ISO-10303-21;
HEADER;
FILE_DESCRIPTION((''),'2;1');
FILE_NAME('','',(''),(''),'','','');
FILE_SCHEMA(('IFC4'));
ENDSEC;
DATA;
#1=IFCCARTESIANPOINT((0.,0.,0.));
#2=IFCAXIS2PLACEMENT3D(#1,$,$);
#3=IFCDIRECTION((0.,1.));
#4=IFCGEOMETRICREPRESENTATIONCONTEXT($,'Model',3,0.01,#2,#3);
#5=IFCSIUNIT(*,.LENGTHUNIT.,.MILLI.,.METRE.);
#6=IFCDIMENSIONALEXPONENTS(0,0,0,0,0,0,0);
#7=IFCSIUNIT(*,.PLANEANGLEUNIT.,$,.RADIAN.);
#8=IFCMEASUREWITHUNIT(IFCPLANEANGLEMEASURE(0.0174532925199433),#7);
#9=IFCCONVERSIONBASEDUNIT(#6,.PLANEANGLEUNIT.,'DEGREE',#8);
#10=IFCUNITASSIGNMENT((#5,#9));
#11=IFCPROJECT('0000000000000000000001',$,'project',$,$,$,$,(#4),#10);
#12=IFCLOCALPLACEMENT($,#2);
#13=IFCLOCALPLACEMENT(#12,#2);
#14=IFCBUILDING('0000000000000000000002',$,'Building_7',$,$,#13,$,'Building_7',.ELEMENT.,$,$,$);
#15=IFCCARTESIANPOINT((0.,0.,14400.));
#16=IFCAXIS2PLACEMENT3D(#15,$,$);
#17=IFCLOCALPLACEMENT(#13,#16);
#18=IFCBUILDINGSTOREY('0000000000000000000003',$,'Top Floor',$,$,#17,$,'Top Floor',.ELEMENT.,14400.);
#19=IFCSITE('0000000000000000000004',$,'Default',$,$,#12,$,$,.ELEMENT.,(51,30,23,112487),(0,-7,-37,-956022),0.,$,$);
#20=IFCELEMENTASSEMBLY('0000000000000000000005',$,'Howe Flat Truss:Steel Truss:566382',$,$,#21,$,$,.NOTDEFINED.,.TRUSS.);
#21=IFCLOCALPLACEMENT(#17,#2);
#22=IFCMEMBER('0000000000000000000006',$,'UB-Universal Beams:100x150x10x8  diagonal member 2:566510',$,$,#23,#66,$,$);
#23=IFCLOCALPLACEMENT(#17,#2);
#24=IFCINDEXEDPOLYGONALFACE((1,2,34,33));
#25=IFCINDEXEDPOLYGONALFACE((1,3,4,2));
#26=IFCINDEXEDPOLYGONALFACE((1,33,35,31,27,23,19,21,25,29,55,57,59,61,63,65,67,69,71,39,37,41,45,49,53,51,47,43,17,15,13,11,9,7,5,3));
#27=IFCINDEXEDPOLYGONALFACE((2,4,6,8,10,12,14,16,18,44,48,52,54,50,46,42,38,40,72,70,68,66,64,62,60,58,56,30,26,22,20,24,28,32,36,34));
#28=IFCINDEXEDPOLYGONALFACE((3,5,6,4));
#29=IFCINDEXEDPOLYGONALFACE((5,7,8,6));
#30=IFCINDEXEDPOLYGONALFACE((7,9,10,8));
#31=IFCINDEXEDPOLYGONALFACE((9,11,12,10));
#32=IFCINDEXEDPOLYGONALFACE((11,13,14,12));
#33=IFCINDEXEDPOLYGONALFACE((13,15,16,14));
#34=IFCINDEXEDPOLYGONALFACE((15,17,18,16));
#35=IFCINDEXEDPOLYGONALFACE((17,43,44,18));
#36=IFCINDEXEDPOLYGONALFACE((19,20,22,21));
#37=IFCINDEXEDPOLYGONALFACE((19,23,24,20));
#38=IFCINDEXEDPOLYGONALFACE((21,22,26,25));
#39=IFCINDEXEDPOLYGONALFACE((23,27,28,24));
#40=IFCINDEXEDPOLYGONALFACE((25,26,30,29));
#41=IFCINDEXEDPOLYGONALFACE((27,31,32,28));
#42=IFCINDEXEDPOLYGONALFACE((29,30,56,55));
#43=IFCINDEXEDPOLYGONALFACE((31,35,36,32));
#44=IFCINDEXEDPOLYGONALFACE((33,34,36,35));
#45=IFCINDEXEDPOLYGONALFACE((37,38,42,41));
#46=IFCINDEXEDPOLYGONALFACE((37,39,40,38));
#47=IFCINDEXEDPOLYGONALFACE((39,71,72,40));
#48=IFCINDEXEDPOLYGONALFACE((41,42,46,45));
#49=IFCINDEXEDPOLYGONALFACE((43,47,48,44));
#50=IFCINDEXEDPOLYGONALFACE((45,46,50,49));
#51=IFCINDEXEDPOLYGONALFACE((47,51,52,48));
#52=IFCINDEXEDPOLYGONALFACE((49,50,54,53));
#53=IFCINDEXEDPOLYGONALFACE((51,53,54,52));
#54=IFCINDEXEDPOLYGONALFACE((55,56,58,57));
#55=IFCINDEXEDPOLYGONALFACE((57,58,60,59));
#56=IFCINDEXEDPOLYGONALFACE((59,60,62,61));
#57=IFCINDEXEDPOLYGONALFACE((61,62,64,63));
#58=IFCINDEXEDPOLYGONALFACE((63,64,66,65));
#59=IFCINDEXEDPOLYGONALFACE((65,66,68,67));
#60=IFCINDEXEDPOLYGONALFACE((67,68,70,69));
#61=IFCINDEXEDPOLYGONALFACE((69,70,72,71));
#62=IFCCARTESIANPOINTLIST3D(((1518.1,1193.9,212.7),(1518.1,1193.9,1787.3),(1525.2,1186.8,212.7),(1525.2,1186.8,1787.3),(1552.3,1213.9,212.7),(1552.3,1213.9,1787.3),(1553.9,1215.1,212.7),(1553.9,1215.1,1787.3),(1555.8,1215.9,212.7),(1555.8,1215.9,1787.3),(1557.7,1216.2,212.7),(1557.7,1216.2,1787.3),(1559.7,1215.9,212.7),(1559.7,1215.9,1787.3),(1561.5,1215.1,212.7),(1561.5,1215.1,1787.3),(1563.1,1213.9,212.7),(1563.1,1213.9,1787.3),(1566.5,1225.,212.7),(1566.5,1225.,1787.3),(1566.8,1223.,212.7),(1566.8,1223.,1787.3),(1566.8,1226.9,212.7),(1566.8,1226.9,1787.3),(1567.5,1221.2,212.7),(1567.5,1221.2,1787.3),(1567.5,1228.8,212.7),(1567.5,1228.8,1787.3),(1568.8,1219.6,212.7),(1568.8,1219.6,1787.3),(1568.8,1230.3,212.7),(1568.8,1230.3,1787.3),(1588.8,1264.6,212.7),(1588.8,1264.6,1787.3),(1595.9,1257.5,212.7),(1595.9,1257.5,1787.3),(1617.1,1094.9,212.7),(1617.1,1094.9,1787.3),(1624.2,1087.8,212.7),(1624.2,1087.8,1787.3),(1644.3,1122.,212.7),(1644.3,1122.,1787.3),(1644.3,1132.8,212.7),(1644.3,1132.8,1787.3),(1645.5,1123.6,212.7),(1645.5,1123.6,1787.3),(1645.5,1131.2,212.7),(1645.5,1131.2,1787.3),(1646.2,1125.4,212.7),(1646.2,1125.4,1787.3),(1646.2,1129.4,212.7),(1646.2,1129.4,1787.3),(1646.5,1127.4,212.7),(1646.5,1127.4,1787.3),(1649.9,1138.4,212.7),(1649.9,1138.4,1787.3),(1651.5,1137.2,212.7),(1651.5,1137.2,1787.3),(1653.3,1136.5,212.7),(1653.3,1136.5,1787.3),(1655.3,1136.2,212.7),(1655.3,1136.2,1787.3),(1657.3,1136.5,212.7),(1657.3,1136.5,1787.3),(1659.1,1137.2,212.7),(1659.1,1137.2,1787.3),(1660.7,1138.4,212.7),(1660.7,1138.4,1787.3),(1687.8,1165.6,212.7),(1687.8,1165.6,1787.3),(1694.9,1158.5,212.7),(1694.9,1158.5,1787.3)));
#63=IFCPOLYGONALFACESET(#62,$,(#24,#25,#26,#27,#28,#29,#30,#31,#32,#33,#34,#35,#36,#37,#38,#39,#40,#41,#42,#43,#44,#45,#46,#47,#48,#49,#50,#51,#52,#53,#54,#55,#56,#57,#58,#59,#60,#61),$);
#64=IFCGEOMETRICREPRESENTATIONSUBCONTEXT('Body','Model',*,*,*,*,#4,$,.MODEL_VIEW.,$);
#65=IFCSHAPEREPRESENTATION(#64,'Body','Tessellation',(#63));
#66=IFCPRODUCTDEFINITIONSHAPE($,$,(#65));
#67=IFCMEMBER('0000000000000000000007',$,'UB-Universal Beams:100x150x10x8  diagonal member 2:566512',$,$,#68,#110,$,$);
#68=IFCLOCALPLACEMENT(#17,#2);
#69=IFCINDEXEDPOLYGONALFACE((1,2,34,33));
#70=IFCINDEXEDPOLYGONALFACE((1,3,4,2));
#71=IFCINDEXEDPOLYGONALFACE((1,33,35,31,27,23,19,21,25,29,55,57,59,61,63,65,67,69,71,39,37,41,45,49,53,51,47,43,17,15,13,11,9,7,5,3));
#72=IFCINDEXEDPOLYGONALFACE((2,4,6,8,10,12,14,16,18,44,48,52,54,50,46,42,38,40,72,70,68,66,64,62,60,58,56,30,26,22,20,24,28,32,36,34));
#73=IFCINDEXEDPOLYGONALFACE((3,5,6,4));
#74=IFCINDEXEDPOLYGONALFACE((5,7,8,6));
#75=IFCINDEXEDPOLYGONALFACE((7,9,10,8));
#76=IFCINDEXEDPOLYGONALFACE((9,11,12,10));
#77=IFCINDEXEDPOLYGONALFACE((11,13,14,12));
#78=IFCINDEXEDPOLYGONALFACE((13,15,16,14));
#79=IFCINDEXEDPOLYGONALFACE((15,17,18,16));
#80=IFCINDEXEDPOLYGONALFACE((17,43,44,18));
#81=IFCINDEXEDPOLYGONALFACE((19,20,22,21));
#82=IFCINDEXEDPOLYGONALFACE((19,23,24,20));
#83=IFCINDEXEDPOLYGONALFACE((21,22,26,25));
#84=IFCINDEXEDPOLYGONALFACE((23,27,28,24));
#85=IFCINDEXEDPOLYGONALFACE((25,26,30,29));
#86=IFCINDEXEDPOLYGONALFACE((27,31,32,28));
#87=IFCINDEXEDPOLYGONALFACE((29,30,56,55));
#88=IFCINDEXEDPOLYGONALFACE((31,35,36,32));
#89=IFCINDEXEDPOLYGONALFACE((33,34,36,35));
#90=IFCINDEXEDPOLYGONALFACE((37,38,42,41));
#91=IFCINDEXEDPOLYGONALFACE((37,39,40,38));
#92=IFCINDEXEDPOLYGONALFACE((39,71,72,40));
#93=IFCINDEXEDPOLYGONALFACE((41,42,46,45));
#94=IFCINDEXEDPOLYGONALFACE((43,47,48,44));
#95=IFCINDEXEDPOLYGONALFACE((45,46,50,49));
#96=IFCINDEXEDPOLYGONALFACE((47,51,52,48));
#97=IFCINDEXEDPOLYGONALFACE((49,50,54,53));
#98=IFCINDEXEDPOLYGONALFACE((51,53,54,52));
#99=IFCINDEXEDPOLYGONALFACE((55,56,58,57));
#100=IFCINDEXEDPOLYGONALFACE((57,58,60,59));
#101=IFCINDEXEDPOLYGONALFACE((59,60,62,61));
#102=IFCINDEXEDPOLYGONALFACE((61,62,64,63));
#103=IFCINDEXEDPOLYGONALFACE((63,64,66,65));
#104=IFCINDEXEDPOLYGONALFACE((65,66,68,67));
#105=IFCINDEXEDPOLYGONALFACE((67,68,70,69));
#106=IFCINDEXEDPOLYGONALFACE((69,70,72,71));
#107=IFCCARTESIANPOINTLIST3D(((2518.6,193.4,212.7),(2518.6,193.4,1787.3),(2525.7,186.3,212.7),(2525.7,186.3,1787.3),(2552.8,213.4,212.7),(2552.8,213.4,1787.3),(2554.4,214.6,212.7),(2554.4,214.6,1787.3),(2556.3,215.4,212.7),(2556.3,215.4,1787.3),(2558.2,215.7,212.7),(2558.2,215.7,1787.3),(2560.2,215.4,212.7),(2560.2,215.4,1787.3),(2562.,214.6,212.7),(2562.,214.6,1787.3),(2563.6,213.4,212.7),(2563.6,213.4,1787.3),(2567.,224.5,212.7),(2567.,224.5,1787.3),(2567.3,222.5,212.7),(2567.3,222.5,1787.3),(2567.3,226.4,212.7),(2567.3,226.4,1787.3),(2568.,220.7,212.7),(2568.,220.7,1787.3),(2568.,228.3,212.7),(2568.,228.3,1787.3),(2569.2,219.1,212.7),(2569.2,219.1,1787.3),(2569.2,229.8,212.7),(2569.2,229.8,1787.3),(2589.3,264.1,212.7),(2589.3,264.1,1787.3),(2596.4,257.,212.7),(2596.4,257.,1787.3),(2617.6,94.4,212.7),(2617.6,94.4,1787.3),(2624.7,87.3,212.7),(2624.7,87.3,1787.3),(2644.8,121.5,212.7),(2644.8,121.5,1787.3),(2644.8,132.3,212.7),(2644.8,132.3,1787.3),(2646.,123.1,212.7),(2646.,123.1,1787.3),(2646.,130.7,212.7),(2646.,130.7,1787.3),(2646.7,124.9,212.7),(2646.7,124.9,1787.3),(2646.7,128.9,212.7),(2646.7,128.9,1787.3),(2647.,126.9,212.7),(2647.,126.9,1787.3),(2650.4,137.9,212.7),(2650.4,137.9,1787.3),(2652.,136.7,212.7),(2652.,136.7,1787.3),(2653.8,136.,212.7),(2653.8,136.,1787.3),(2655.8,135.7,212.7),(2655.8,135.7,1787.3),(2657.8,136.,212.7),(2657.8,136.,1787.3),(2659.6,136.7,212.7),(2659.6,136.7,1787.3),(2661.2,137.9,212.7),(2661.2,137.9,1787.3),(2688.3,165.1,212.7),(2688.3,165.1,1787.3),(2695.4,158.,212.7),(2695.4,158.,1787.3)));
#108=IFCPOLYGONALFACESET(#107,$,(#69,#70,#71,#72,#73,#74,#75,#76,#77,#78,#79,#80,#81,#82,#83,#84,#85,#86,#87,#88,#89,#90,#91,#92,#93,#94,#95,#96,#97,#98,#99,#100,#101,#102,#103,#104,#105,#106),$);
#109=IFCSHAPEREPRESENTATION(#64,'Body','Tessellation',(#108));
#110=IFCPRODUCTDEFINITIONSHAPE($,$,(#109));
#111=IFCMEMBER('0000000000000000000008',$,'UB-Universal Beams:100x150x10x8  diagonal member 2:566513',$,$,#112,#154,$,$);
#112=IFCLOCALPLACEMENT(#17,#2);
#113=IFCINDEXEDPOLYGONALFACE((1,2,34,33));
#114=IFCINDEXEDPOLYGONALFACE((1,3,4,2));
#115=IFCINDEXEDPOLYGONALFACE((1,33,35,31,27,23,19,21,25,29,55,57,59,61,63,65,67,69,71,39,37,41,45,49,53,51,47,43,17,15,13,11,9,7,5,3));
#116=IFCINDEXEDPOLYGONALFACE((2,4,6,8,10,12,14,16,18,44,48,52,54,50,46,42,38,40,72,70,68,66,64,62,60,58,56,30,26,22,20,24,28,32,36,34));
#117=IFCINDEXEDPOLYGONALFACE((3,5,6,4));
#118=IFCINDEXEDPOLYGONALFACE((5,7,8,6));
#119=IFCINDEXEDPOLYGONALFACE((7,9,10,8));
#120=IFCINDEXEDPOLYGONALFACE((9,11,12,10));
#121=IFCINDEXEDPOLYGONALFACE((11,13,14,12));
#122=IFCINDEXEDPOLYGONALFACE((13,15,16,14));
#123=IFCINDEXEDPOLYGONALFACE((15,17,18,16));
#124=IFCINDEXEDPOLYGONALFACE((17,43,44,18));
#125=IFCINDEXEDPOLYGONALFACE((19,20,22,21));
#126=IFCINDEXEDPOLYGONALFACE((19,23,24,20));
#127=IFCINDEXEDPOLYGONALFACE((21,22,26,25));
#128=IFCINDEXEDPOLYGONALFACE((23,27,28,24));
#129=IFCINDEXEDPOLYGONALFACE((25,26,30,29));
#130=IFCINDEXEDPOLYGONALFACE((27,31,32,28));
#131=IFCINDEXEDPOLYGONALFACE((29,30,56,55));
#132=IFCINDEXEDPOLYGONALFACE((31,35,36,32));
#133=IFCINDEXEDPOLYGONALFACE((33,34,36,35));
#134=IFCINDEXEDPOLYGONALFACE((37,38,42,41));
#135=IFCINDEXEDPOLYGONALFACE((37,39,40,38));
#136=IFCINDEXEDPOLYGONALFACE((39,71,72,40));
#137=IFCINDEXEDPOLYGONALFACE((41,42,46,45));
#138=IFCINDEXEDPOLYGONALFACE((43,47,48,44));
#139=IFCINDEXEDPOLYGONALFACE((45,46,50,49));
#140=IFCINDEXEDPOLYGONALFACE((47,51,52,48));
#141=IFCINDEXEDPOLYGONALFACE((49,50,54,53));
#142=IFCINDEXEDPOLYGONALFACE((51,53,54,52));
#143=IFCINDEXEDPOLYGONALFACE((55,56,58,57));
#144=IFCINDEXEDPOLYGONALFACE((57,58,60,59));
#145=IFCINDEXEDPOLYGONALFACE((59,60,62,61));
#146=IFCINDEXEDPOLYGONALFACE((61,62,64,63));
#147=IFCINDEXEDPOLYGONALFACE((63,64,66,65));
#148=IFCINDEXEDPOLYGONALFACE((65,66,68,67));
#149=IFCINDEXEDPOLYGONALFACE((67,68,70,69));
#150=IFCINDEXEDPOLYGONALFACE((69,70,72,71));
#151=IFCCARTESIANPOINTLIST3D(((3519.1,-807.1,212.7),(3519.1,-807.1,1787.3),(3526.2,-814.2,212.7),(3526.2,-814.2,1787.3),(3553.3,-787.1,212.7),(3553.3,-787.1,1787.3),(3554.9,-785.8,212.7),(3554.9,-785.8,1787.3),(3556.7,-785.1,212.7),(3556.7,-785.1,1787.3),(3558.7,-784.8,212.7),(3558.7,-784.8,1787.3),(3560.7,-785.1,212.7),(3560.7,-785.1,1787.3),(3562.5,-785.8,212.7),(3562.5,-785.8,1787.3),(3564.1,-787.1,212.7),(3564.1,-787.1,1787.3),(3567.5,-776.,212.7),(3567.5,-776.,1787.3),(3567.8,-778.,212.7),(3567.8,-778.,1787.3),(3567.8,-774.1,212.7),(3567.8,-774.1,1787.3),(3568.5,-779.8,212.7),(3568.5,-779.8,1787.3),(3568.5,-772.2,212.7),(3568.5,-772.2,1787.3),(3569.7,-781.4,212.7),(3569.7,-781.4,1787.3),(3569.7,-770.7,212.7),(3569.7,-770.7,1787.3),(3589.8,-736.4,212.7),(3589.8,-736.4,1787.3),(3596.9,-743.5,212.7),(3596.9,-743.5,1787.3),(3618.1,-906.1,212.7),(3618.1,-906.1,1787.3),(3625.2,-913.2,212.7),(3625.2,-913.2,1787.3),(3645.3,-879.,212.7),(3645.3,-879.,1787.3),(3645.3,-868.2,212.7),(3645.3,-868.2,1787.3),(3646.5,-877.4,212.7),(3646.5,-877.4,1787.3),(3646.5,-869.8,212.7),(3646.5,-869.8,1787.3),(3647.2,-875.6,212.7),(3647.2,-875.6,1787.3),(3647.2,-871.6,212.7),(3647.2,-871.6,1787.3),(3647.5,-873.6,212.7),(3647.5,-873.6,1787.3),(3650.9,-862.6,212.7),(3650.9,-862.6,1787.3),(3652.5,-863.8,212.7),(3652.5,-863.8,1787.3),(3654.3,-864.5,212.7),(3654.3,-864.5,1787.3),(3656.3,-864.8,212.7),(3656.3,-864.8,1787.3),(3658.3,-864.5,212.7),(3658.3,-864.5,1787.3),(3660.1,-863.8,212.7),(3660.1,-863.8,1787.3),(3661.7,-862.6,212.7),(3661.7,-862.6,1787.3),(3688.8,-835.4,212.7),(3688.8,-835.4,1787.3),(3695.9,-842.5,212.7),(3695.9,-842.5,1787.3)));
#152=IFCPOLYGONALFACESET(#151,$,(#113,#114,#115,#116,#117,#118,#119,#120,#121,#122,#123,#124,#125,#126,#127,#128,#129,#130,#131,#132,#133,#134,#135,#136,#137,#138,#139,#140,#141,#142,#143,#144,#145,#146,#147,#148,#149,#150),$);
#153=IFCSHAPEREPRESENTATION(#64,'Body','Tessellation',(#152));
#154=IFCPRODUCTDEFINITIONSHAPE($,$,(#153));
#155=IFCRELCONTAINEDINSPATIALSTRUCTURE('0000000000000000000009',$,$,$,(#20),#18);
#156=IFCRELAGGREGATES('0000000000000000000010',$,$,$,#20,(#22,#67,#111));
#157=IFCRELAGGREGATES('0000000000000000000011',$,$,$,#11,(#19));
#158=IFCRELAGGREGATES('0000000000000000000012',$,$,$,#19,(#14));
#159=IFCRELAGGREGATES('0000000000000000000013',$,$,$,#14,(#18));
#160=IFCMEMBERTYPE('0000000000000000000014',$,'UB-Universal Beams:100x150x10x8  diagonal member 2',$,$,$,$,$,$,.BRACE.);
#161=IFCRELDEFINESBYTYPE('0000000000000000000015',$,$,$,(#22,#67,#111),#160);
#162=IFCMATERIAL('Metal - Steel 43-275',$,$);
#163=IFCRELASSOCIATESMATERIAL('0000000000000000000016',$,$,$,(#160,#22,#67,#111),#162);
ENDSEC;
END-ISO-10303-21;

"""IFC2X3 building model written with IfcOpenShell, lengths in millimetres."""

from ifc_helpers import new_model, entity, si_unit, converted_unit, direction, frame, frame_2d, origin, place, context, subcontext, project, spatial, polyline, circle_curve, parameter, trimmed, segment, composite_curve, outline, extrude, source, transform, mapped, material, type_object, type_shapes, element, aggregate, save


model = new_model("IFC2X3")

# Units and contexts
model_context = context("Model", 3, precision=0.01, world=origin(), true_north=direction((0.0, 1.0)))
body_context = subcontext(model_context, "Body", "Model", "MODEL_VIEW")
ifc_project = project(units=[si_unit("LENGTHUNIT", "METRE", prefix="MILLI"), converted_unit("PLANEANGLEUNIT", "DEGREE", entity("IfcPlaneAngleMeasure", 0.0174532925199433), si_unit("PLANEANGLEUNIT", "RADIAN"), dimensions=[0, 0, 0, 0, 0, 0, 0])], contexts=[model_context])

# Site, building, storey
site_placement = place(None, origin())
site = spatial("IfcSite", under=ifc_project, at=site_placement, Name="Default", CompositionType="ELEMENT", RefLatitude=(51, 30, 23, 112487), RefLongitude=(0, -7, -37, -956022), RefElevation=0.0)
building_placement = place(site_placement, origin())
building = spatial("IfcBuilding", under=site, at=building_placement, Name="Building_7", LongName="Building_7", CompositionType="ELEMENT")
storey_placement = place(building_placement, frame((0.0, 0.0, 14400.0)))
storey = spatial("IfcBuildingStorey", under=building, at=storey_placement, Name="Top Floor", LongName="Top Floor", CompositionType="ELEMENT", Elevation=14400.0)

# Shared definitions
ifc_material = material(Name="Metal - Steel 43-275")

# Shared definitions
member_type_1 = type_object("IfcMemberType", Name="UB-Universal Beams:100x150x10x8  diagonal member 2", PredefinedType="BRACE", material=ifc_material)
shared_shape_1 = source(origin(), body_context, "Body", "SweptSolid", [
    extrude(outline(composite_curve([segment(polyline([(-50.0, -65.0), (-50.0, -75.0)]), True, "CONTINUOUS"), segment(polyline([(-50.0, -75.0), (50.0, -75.0)]), True, "CONTINUOUS"), segment(polyline([(50.0, -75.0), (50.0, -65.0)]), True, "CONTINUOUS"), segment(polyline([(50.0, -65.0), (11.6, -65.0)]), True, "CONTINUOUS"), segment(trimmed(circle_curve(frame_2d((11.6, -57.4), x_axis=(1.0, 0.0)), 7.6), [parameter(180.0)], [parameter(270.0)], True, "PARAMETER"), False, "CONTINUOUS"), segment(polyline([(4.0, -57.4), (4.0, 57.4)]), True, "CONTINUOUS"), segment(trimmed(circle_curve(frame_2d((11.6, 57.4), x_axis=(1.0, 0.0)), 7.6), [parameter(90.0)], [parameter(180.0)], True, "PARAMETER"), False, "CONTINUOUS"), segment(polyline([(11.6, 65.0), (50.0, 65.0)]), True, "CONTINUOUS"), segment(polyline([(50.0, 65.0), (50.0, 75.0)]), True, "CONTINUOUS"), segment(polyline([(50.0, 75.0), (-50.0, 75.0)]), True, "CONTINUOUS"), segment(polyline([(-50.0, 75.0), (-50.0, 65.0)]), True, "CONTINUOUS"), segment(polyline([(-50.0, 65.0), (-11.6, 65.0)]), True, "CONTINUOUS"), segment(trimmed(circle_curve(frame_2d((-11.6, 57.4), x_axis=(1.0, 0.0)), 7.6), [parameter(360.0)], [parameter(90.0)], True, "PARAMETER"), False, "CONTINUOUS"), segment(polyline([(-4.0, 57.4), (-4.0, -57.4)]), True, "CONTINUOUS"), segment(trimmed(circle_curve(frame_2d((-11.6, -57.4), x_axis=(1.0, 0.0)), 7.6), [parameter(270.0)], [parameter(360.0)], True, "PARAMETER"), False, "CONTINUOUS"), segment(polyline([(-11.6, -65.0), (-50.0, -65.0)]), True, "CONTINUOUS")], self_intersect=False)), frame((-787.3, 0.0, 0.0), z_axis=(-1.0, 0.0, 0.0), x_axis=(0.0, -1.0, 0.0)), (0.0, 0.0, -1.0), 1574.6),
])
type_shapes(member_type_1, [shared_shape_1])

# Element assembly, members
assembly_1_placement = place(storey_placement, origin())
assembly_1 = element("IfcElementAssembly", 1, at=assembly_1_placement, inside=storey, Name="Howe Flat Truss:Steel Truss:566382", AssemblyPlace="NOTDEFINED", PredefinedType="TRUSS")
member_1_placement = place(assembly_1_placement, frame((1606.5, 1176.2, 1000.0), z_axis=(-0.707107, 0.707107, 0.0), x_axis=(0.0, 0.0, 1.0)))
member_1 = element("IfcMember", 2, at=member_1_placement, type_object=member_type_1, material=ifc_material, Name="UB-Universal Beams:100x150x10x8  diagonal member 2:566510", context=body_context, shape_type="MappedRepresentation", body=[
    mapped(shared_shape_1, transform((0.0, 0.0, 0.0), scale=1.0)),
])
member_2_placement = place(assembly_1_placement, frame((2607.0, 175.7, 1000.0), z_axis=(-0.707107, 0.707107, 0.0), x_axis=(0.0, 0.0, 1.0)))
member_2 = element("IfcMember", 3, at=member_2_placement, type_object=member_type_1, material=ifc_material, Name="UB-Universal Beams:100x150x10x8  diagonal member 2:566512", context=body_context, shape_type="MappedRepresentation", body=[
    mapped(shared_shape_1, transform((0.0, 0.0, 0.0), scale=1.0)),
])
member_3_placement = place(assembly_1_placement, frame((3607.5, -824.8, 1000.0), z_axis=(-0.707107, 0.707107, 0.0), x_axis=(0.0, 0.0, 1.0)))
member_3 = element("IfcMember", 4, at=member_3_placement, type_object=member_type_1, material=ifc_material, Name="UB-Universal Beams:100x150x10x8  diagonal member 2:566513", context=body_context, shape_type="MappedRepresentation", body=[
    mapped(shared_shape_1, transform((0.0, 0.0, 0.0), scale=1.0)),
])

aggregate(assembly_1, [member_1, member_2, member_3])

save(model, "model.ifc")
